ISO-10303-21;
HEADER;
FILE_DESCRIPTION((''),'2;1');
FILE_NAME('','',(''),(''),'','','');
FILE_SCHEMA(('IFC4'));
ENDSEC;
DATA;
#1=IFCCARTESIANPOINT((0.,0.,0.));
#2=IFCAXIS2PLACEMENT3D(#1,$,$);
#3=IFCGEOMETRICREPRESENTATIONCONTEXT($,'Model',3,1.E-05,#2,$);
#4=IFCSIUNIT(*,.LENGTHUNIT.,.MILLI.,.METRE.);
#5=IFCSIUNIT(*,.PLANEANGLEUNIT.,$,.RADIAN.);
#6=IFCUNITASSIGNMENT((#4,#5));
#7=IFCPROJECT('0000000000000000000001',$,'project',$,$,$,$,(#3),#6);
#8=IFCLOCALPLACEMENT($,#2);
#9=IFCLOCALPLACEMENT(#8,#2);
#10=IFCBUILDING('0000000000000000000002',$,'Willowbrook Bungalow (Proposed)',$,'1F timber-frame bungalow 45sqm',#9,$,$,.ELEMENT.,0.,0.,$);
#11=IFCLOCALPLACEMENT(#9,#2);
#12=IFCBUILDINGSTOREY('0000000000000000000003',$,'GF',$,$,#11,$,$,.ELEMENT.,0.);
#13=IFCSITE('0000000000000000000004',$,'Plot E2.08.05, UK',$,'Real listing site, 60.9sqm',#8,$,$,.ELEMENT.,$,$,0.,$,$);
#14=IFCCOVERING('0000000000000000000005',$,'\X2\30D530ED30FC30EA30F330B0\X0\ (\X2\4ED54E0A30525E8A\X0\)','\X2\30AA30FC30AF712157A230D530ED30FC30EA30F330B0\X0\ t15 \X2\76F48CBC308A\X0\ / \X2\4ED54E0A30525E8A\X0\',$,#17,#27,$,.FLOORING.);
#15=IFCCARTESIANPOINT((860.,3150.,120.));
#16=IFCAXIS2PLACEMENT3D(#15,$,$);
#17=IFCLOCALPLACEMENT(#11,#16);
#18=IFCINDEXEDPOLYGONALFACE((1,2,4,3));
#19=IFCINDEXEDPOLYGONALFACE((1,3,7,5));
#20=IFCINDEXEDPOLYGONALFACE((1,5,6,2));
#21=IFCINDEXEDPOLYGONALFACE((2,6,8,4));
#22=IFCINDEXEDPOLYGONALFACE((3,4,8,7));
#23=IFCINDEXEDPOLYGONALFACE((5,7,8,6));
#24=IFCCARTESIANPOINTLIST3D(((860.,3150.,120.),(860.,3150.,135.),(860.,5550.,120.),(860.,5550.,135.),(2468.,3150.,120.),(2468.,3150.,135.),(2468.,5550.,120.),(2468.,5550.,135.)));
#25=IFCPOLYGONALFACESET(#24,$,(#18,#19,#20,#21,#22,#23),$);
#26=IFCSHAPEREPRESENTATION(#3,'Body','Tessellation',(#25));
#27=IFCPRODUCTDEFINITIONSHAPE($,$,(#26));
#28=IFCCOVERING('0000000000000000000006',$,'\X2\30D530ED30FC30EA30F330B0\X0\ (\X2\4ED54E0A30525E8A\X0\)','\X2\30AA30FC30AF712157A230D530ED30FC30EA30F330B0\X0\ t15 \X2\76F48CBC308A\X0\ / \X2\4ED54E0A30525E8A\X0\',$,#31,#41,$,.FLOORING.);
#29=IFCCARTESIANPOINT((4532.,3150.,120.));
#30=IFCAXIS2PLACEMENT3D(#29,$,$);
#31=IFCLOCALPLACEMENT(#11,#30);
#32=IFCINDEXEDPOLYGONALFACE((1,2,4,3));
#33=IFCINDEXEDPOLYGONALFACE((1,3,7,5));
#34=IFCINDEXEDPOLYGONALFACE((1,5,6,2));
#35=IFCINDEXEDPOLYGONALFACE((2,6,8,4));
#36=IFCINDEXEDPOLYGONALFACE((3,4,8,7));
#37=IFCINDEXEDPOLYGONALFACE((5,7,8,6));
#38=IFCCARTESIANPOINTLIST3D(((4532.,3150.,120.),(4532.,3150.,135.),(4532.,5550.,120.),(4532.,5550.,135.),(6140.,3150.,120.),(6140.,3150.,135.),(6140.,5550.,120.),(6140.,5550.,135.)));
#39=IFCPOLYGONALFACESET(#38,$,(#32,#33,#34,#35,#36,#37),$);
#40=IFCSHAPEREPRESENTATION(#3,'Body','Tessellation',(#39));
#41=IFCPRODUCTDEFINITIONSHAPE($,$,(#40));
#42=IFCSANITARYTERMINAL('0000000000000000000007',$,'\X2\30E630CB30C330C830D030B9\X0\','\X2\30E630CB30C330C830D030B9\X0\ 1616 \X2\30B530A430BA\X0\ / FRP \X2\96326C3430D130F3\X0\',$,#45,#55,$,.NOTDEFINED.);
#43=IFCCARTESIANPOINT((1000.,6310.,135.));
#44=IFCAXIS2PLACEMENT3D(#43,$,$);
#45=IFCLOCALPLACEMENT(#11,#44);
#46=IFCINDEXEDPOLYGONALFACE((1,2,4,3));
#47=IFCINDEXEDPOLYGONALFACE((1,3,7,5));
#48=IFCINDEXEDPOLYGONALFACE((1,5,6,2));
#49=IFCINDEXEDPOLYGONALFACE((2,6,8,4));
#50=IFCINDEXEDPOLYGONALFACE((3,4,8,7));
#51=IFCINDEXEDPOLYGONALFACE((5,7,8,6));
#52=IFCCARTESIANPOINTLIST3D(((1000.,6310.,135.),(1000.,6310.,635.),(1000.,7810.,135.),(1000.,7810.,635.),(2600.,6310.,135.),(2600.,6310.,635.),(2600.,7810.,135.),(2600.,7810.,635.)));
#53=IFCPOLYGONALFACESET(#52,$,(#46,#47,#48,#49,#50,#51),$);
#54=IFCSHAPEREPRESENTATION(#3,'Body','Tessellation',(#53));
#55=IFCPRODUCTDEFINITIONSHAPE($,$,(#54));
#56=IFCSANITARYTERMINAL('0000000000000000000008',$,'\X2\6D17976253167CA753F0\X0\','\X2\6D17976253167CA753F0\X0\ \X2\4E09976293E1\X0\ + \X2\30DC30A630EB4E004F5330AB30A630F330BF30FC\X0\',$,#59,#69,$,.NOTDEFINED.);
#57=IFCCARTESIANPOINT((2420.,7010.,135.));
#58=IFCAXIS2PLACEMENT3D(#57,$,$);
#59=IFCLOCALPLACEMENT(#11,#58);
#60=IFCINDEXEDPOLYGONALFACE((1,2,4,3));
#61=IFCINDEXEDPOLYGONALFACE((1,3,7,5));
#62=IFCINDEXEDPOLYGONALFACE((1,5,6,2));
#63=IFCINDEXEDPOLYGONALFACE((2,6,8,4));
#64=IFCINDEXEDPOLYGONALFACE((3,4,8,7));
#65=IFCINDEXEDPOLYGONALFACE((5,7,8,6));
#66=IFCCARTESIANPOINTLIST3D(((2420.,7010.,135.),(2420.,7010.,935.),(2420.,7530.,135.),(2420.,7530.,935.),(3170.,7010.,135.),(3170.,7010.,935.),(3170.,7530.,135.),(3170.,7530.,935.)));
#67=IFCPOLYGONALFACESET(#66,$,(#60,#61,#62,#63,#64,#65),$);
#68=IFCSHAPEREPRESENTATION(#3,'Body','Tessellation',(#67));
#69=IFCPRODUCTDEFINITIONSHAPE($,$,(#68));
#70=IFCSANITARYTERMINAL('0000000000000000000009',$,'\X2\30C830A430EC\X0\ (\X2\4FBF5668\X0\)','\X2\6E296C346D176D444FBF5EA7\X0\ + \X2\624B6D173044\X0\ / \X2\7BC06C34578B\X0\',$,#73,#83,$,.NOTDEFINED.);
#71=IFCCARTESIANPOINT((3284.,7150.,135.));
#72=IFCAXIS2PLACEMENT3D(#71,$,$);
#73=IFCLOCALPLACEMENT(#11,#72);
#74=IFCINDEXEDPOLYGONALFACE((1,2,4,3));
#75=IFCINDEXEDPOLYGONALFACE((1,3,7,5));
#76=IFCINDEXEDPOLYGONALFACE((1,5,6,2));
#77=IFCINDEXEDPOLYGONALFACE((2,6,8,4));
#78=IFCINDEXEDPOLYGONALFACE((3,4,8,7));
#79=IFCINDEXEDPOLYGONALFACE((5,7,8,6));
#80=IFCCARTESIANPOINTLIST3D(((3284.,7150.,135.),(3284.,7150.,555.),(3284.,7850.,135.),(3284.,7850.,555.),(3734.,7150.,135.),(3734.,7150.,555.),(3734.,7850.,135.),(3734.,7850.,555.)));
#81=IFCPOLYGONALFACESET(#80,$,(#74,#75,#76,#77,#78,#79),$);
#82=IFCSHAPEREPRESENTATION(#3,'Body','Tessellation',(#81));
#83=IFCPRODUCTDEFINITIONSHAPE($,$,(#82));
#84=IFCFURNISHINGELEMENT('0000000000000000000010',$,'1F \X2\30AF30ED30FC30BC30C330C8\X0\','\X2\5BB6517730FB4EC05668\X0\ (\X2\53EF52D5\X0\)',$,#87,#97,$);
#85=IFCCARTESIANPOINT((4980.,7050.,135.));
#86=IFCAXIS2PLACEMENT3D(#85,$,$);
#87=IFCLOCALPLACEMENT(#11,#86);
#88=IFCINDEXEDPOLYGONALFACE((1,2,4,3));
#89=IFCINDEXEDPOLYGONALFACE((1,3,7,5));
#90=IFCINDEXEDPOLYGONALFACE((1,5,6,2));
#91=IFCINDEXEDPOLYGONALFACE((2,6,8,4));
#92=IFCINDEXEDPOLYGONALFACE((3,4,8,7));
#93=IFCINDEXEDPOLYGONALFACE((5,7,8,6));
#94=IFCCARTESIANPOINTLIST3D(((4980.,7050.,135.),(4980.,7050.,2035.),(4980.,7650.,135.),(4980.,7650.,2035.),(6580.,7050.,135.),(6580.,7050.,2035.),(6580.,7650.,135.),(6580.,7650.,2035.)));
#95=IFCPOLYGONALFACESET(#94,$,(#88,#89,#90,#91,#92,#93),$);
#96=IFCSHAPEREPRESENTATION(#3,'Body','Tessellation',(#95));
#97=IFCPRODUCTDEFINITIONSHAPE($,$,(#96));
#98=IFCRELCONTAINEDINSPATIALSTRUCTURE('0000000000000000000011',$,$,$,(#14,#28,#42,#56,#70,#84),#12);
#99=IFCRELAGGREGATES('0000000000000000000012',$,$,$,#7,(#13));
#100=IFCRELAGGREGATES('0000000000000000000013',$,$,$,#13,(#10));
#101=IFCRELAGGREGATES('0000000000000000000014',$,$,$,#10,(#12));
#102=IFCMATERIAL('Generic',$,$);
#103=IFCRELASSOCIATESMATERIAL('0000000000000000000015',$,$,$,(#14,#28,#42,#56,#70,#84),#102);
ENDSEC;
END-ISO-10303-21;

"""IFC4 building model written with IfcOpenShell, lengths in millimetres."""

from ifc_helpers import new_model, si_unit, frame, frame_2d, origin, place, context, project, spatial, rectangle, extrude, material, element, save


model = new_model("IFC4")

# Units and contexts
model_context = context("Model", 3, precision=1e-05, world=origin())
ifc_project = project(units=[si_unit("LENGTHUNIT", "METRE", prefix="MILLI"), si_unit("PLANEANGLEUNIT", "RADIAN")], contexts=[model_context])

# Site, building, storey
site_placement = place(None, origin())
site = spatial("IfcSite", under=ifc_project, at=site_placement, Name="Plot E2.08.05, UK", ObjectType="Real listing site, 60.9sqm", CompositionType="ELEMENT", RefElevation=0.0)
building_placement = place(site_placement, origin())
building = spatial("IfcBuilding", under=site, at=building_placement, Name="Willowbrook Bungalow (Proposed)", ObjectType="1F timber-frame bungalow 45sqm", CompositionType="ELEMENT", ElevationOfRefHeight=0.0, ElevationOfTerrain=0.0)
storey_placement = place(building_placement, origin())
storey = spatial("IfcBuildingStorey", under=building, at=storey_placement, Name="GF", CompositionType="ELEMENT", Elevation=0.0)

# Coverings
ifc_material_1 = material(Name="Generic")
covering_1_placement = place(storey_placement, frame((860.0, 3150.0, 120.0)))
element("IfcCovering", 1, at=covering_1_placement, inside=storey, material=ifc_material_1, Name="フローリング (仕上げ床)", Description="オーク無垢フローリング t15 直貼り / 仕上げ床", PredefinedType="FLOORING", context=model_context, shape_type="SweptSolid", body=[
    extrude(rectangle(XDim=1608.0, YDim=2400.0, at=frame_2d((804.0, 1200.0))), frame((860.0, 3150.0, 120.0)), (0.0, 0.0, 1.0), 15.0),
])
covering_2_placement = place(storey_placement, frame((4532.0, 3150.0, 120.0)))
element("IfcCovering", 2, at=covering_2_placement, inside=storey, material=ifc_material_1, Name="フローリング (仕上げ床)", Description="オーク無垢フローリング t15 直貼り / 仕上げ床", PredefinedType="FLOORING", context=model_context, shape_type="SweptSolid", body=[
    extrude(rectangle(XDim=1608.0, YDim=2400.0, at=frame_2d((804.0, 1200.0))), frame((4532.0, 3150.0, 120.0)), (0.0, 0.0, 1.0), 15.0),
])

# Sanitary terminals
sanitary_terminal_1_placement = place(storey_placement, frame((1000.0, 6310.0, 135.0)))
element("IfcSanitaryTerminal", 3, at=sanitary_terminal_1_placement, inside=storey, material=ifc_material_1, Name="ユニットバス", Description="ユニットバス 1616 サイズ / FRP 防水パン", PredefinedType="NOTDEFINED", context=model_context, shape_type="SweptSolid", body=[
    extrude(rectangle(XDim=1600.0, YDim=1500.0, at=frame_2d((800.0, 750.0))), frame((1000.0, 6310.0, 135.0)), (0.0, 0.0, 1.0), 500.0),
])
sanitary_terminal_2_placement = place(storey_placement, frame((2420.0, 7010.0, 135.0)))
element("IfcSanitaryTerminal", 4, at=sanitary_terminal_2_placement, inside=storey, material=ifc_material_1, Name="洗面化粧台", Description="洗面化粧台 三面鏡 + ボウル一体カウンター", PredefinedType="NOTDEFINED", context=model_context, shape_type="SweptSolid", body=[
    extrude(rectangle(XDim=750.0, YDim=520.0, at=frame_2d((375.0, 260.0))), frame((2420.0, 7010.0, 135.0)), (0.0, 0.0, 1.0), 800.0),
])
sanitary_terminal_3_placement = place(storey_placement, frame((3284.0, 7150.0, 135.0)))
element("IfcSanitaryTerminal", 5, at=sanitary_terminal_3_placement, inside=storey, material=ifc_material_1, Name="トイレ (便器)", Description="温水洗浄便座 + 手洗い / 節水型", PredefinedType="NOTDEFINED", context=model_context, shape_type="SweptSolid", body=[
    extrude(rectangle(XDim=450.0, YDim=700.0, at=frame_2d((225.0, 350.0))), frame((3284.0, 7150.0, 135.0)), (0.0, 0.0, 1.0), 420.0),
])

# Furnishing element
furnishing_placement = place(storey_placement, frame((4980.0, 7050.0, 135.0)))
element("IfcFurnishingElement", 6, at=furnishing_placement, inside=storey, material=ifc_material_1, Name="1F クローゼット", Description="家具・什器 (可動)", context=model_context, shape_type="SweptSolid", body=[
    extrude(rectangle(XDim=1600.0, YDim=600.0, at=frame_2d((800.0, 300.0))), frame((4980.0, 7050.0, 135.0)), (0.0, 0.0, 1.0), 1900.0),
])

save(model, "model.ifc")
